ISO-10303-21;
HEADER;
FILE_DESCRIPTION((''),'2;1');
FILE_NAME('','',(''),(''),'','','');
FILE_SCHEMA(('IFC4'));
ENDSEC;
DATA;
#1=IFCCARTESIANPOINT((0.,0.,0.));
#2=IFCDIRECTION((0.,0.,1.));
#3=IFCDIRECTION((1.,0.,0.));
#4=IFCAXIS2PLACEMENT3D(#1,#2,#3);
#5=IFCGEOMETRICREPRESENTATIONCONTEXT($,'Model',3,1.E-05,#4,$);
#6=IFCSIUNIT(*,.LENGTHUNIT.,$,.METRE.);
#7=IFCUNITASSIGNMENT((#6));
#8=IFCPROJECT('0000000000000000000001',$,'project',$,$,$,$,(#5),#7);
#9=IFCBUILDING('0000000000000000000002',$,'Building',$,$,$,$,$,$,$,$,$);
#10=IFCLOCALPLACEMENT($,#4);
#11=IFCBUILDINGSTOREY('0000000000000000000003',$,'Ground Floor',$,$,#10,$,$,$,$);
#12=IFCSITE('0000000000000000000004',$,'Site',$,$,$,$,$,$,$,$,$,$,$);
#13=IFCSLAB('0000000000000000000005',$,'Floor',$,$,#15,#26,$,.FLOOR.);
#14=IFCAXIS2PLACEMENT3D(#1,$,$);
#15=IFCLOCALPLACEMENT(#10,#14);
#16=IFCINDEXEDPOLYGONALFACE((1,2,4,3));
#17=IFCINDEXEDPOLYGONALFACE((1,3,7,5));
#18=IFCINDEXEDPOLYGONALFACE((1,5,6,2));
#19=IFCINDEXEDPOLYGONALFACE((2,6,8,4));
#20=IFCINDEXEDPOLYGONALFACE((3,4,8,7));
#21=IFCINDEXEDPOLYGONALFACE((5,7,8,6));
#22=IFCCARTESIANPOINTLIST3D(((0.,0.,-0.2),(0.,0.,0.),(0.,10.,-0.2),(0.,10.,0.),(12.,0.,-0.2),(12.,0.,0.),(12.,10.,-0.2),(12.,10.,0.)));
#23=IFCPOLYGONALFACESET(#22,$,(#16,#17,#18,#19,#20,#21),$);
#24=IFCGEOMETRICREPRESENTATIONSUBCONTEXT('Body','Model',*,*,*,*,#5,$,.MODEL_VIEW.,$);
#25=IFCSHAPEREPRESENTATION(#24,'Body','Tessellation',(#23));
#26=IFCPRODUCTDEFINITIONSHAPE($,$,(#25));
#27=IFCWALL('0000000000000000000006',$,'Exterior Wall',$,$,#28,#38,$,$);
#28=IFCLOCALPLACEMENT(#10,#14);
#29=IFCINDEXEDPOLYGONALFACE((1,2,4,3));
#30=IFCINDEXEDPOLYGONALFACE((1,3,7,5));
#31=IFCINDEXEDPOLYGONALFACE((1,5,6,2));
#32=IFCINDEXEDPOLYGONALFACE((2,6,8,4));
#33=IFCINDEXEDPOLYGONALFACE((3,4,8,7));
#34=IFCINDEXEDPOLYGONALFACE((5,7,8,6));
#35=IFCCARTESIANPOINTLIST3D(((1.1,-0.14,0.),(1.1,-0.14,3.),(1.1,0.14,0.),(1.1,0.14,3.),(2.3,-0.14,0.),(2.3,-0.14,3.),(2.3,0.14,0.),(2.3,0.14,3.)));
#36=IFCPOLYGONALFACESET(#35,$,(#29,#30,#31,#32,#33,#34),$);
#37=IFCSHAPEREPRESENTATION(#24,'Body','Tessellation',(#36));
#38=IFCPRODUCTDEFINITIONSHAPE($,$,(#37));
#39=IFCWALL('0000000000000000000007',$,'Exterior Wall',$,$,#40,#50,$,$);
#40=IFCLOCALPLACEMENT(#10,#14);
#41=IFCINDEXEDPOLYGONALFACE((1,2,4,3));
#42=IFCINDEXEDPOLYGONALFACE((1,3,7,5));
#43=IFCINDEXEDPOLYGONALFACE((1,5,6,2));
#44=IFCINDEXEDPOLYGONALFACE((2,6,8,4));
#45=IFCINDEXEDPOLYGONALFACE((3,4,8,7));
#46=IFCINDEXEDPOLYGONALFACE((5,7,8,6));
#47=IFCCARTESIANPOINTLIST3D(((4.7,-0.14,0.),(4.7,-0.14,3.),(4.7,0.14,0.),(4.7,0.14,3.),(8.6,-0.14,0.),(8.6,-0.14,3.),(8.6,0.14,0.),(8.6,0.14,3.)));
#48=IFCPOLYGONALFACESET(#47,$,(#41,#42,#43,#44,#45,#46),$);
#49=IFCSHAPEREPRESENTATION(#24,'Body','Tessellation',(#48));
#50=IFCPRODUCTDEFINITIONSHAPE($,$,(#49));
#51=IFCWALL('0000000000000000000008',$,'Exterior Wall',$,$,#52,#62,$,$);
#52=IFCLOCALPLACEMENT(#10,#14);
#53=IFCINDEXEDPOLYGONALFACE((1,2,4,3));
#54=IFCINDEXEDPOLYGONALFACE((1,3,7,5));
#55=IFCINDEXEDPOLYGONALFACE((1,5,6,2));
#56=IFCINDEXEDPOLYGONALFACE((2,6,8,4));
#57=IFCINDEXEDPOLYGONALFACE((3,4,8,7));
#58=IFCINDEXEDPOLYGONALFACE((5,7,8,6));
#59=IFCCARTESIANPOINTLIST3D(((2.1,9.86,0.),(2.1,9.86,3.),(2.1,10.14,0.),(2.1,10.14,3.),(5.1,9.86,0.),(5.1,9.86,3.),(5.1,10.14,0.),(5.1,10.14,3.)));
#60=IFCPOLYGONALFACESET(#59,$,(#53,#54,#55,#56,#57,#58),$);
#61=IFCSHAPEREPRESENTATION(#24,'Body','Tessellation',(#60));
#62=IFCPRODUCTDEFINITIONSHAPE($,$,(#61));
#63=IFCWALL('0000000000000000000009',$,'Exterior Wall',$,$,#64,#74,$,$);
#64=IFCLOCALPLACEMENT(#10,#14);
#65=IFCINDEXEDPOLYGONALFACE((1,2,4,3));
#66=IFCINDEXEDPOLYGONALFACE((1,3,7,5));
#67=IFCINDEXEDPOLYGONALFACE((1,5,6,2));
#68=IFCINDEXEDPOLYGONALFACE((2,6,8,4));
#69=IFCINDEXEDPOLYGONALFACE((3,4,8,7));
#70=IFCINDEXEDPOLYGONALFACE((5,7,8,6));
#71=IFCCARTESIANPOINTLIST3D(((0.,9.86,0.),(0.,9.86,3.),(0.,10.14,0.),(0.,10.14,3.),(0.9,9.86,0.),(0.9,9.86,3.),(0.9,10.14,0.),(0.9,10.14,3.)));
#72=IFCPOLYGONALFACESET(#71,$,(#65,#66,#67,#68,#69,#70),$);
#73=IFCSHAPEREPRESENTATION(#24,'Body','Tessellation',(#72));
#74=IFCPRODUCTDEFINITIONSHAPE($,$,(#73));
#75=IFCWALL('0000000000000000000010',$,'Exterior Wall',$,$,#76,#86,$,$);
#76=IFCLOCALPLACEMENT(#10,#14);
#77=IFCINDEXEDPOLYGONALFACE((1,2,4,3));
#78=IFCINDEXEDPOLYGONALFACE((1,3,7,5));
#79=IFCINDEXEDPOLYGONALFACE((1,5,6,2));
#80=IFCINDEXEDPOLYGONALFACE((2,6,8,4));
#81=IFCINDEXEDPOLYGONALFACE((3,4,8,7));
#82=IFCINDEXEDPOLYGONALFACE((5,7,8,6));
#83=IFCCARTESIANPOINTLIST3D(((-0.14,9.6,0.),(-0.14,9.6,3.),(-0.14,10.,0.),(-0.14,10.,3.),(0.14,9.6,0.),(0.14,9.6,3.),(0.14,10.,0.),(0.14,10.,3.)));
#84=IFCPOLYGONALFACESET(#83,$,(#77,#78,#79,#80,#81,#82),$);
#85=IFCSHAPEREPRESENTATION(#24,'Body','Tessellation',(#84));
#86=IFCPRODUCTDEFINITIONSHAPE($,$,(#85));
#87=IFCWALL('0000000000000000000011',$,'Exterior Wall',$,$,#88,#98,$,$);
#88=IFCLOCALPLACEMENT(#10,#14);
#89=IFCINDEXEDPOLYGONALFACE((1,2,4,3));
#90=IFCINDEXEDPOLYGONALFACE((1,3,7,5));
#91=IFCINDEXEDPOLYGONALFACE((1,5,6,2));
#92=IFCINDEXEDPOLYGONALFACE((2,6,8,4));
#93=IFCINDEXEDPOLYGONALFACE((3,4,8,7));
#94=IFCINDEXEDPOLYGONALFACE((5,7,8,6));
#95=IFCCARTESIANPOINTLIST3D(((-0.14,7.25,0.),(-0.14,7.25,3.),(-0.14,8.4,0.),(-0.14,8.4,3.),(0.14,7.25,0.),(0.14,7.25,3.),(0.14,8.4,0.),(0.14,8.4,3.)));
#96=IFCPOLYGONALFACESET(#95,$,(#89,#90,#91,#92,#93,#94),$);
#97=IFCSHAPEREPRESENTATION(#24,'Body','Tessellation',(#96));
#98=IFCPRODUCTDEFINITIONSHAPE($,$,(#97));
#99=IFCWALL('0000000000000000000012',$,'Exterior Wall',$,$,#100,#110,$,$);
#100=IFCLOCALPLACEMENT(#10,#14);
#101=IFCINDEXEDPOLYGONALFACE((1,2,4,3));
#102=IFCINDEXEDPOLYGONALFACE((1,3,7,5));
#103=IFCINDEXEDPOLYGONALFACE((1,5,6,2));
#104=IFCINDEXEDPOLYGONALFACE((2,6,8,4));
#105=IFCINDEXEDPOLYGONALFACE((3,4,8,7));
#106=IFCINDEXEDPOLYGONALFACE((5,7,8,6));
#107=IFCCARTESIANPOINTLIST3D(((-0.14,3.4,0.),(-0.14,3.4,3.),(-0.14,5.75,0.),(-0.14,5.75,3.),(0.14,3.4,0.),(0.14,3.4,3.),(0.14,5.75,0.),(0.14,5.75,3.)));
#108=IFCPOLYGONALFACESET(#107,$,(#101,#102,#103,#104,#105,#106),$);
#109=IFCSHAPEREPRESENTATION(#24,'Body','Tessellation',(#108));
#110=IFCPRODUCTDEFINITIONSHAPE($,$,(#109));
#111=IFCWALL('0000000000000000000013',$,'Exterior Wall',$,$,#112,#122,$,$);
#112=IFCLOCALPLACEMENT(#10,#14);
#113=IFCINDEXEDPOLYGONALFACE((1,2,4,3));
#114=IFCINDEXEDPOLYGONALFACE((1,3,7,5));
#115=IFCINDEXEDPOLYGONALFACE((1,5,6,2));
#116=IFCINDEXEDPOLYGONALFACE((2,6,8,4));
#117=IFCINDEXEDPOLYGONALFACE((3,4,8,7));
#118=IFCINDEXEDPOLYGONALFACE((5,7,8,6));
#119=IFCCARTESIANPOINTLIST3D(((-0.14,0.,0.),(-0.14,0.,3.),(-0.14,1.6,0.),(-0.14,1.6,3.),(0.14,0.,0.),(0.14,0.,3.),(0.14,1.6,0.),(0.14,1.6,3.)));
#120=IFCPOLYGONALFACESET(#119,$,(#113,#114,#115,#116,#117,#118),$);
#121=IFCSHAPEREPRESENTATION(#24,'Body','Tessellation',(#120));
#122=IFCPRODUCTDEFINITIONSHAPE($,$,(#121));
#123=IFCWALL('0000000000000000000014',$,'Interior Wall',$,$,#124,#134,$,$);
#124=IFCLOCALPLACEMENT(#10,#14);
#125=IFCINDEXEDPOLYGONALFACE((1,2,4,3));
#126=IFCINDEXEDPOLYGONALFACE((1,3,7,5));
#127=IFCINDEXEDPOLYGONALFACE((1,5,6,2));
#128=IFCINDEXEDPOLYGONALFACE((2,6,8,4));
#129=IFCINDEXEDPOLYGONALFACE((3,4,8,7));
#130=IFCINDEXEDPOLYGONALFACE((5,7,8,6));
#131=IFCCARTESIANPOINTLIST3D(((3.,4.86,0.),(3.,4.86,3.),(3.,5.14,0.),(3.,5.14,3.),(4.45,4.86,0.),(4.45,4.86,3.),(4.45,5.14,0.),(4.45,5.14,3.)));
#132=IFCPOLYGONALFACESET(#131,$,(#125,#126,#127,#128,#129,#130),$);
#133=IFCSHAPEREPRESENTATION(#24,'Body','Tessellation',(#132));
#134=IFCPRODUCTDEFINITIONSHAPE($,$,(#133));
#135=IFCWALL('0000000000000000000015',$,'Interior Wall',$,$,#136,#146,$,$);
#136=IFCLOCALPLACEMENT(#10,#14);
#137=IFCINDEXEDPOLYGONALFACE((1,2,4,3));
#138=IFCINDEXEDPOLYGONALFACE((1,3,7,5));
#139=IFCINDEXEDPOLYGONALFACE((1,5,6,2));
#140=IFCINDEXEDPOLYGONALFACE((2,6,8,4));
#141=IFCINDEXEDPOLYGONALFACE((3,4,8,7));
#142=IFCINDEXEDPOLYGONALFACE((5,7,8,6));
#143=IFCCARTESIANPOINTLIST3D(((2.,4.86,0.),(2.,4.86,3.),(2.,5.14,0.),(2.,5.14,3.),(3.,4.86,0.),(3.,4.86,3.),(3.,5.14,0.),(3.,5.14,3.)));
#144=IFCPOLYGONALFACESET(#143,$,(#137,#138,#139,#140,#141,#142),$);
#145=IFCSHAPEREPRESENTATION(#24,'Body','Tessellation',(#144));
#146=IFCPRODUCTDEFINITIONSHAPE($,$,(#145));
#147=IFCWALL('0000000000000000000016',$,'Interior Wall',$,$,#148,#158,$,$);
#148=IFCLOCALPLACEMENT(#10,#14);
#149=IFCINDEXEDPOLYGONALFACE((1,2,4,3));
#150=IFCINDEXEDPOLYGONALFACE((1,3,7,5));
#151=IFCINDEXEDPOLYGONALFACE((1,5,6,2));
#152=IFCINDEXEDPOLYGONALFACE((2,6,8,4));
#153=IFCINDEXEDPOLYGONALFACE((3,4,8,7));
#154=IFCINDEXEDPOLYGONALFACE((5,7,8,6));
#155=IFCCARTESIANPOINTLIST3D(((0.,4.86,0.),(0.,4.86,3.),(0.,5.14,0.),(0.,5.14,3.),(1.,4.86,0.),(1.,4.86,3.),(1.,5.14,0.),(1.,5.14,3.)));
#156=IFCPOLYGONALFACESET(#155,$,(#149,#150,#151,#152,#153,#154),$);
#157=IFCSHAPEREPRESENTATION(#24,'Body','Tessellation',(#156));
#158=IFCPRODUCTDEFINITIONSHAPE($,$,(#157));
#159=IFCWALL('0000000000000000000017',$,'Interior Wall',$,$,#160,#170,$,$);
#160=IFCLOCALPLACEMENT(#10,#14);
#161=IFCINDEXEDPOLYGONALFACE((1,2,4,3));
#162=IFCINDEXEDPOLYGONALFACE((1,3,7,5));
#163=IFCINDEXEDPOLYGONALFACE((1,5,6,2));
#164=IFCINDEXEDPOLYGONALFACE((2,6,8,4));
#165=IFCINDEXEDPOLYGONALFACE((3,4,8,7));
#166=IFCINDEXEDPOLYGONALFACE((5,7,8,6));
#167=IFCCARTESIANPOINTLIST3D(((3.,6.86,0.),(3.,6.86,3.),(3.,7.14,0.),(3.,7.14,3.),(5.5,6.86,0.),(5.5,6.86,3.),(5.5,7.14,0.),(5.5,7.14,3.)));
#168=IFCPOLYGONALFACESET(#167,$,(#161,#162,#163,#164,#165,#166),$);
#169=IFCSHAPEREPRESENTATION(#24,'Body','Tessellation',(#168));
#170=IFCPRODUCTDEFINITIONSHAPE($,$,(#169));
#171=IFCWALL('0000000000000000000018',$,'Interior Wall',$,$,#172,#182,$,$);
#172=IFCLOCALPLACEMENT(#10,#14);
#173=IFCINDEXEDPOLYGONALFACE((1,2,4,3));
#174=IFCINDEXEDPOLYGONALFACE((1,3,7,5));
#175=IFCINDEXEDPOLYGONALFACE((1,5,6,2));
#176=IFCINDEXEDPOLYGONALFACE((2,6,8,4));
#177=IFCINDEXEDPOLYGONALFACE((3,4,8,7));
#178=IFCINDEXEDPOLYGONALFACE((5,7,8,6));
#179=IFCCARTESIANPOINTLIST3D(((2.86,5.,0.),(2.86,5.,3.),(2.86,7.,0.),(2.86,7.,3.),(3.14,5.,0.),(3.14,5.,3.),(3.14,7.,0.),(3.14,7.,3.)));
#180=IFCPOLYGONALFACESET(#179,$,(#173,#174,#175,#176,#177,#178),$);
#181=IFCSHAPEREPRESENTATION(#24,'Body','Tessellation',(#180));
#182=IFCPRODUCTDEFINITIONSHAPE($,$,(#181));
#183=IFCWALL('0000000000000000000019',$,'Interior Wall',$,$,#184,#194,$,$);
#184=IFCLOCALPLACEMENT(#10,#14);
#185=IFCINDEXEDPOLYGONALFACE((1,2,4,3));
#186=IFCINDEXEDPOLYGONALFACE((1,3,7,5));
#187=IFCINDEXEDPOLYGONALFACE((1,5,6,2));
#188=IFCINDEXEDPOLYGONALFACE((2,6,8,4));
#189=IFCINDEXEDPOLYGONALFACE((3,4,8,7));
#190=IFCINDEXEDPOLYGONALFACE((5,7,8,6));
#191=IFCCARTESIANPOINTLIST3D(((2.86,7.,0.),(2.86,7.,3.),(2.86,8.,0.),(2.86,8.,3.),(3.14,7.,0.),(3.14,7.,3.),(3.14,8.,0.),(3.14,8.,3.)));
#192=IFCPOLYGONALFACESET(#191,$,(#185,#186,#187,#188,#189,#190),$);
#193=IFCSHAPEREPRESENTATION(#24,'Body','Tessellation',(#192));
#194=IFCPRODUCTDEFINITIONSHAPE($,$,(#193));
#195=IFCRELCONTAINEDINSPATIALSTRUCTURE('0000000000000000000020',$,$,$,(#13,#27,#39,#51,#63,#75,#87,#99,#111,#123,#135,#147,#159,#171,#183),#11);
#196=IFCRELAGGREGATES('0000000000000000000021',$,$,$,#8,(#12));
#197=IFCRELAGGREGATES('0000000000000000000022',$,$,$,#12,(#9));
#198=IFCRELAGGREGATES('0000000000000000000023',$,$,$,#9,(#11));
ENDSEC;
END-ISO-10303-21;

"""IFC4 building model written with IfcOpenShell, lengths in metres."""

from ifc_helpers import new_model, si_unit, frame, origin_with_axes, place, context, subcontext, project, spatial, indexed_curve, outline, extrude, element, save


model = new_model("IFC4")

# Units and contexts
model_context = context("Model", 3, precision=1e-05, world=origin_with_axes())
body_context = subcontext(model_context, "Body", "Model", "MODEL_VIEW")
ifc_project = project(units=[si_unit("LENGTHUNIT", "METRE")], contexts=[model_context])

# Site, building, storey
site = spatial("IfcSite", under=ifc_project, Name="Site")
building = spatial("IfcBuilding", under=site, Name="Building")
storey_placement = place(None, origin_with_axes())
storey = spatial("IfcBuildingStorey", under=building, at=storey_placement, Name="Ground Floor")

# Slab
slab_placement = place(storey_placement, frame((0.0, 0.0, -0.2), z_axis=(0.0, 0.0, 1.0), x_axis=(1.0, 0.0, 0.0)))
element("IfcSlab", 1, at=slab_placement, inside=storey, Name="Floor", PredefinedType="FLOOR", context=body_context, shape_type="SweptSolid", body=[
    extrude(outline(indexed_curve([(0.0, 0.0), (12.0, 0.0), (12.0, 10.0), (0.0, 10.0)])), None, (0.0, 0.0, 1.0), 0.2),
])

# Walls
wall_1_placement = place(storey_placement, frame((1.1, 0.0, 0.0), z_axis=(0.0, 0.0, 1.0), x_axis=(1.0, 0.0, 0.0)))
element("IfcWall", 2, at=wall_1_placement, inside=storey, Name="Exterior Wall", context=body_context, shape_type="SweptSolid", body=[
    extrude(outline(indexed_curve([(0.0, 0.0), (0.0, 0.28), (1.2, 0.28), (1.2, 0.0), (0.0, 0.0)], self_intersect=False)), frame((0.0, -0.14, 0.0), z_axis=(0.0, 0.0, 1.0), x_axis=(1.0, 0.0, 0.0)), (0.0, 0.0, 1.0), 3.0),
])
wall_2_placement = place(storey_placement, frame((4.7, 0.0, 0.0), z_axis=(0.0, 0.0, 1.0), x_axis=(1.0, 0.0, 0.0)))
element("IfcWall", 3, at=wall_2_placement, inside=storey, Name="Exterior Wall", context=body_context, shape_type="SweptSolid", body=[
    extrude(outline(indexed_curve([(0.0, 0.0), (0.0, 0.28), (3.9, 0.28), (3.9, 0.0), (0.0, 0.0)], self_intersect=False)), frame((0.0, -0.14, 0.0), z_axis=(0.0, 0.0, 1.0), x_axis=(1.0, 0.0, 0.0)), (0.0, 0.0, 1.0), 3.0),
])
wall_3_placement = place(storey_placement, frame((5.1, 10.0, 0.0), z_axis=(0.0, 0.0, 1.0), x_axis=(-1.0, 0.0, 0.0)))
element("IfcWall", 4, at=wall_3_placement, inside=storey, Name="Exterior Wall", context=body_context, shape_type="SweptSolid", body=[
    extrude(outline(indexed_curve([(0.0, 0.0), (0.0, 0.28), (3.0, 0.28), (3.0, 0.0), (0.0, 0.0)], self_intersect=False)), frame((0.0, -0.14, 0.0), z_axis=(0.0, 0.0, 1.0), x_axis=(1.0, 0.0, 0.0)), (0.0, 0.0, 1.0), 3.0),
])
wall_4_placement = place(storey_placement, frame((0.9, 10.0, 0.0), z_axis=(0.0, 0.0, 1.0), x_axis=(-1.0, 0.0, 0.0)))
element("IfcWall", 5, at=wall_4_placement, inside=storey, Name="Exterior Wall", context=body_context, shape_type="SweptSolid", body=[
    extrude(outline(indexed_curve([(0.0, 0.0), (0.0, 0.28), (0.9, 0.28), (0.9, 0.0), (0.0, 0.0)], self_intersect=False)), frame((0.0, -0.14, 0.0), z_axis=(0.0, 0.0, 1.0), x_axis=(1.0, 0.0, 0.0)), (0.0, 0.0, 1.0), 3.0),
])
wall_5_placement = place(storey_placement, frame((0.0, 10.0, 0.0), z_axis=(0.0, 0.0, 1.0), x_axis=(0.0, -1.0, 0.0)))
element("IfcWall", 6, at=wall_5_placement, inside=storey, Name="Exterior Wall", context=body_context, shape_type="SweptSolid", body=[
    extrude(outline(indexed_curve([(0.0, 0.0), (0.0, 0.28), (0.4, 0.28), (0.4, 0.0), (0.0, 0.0)], self_intersect=False)), frame((0.0, -0.14, 0.0), z_axis=(0.0, 0.0, 1.0), x_axis=(1.0, 0.0, 0.0)), (0.0, 0.0, 1.0), 3.0),
])
wall_6_placement = place(storey_placement, frame((0.0, 8.4, 0.0), z_axis=(0.0, 0.0, 1.0), x_axis=(0.0, -1.0, 0.0)))
element("IfcWall", 7, at=wall_6_placement, inside=storey, Name="Exterior Wall", context=body_context, shape_type="SweptSolid", body=[
    extrude(outline(indexed_curve([(0.0, 0.0), (0.0, 0.28), (1.15, 0.28), (1.15, 0.0), (0.0, 0.0)], self_intersect=False)), frame((0.0, -0.14, 0.0), z_axis=(0.0, 0.0, 1.0), x_axis=(1.0, 0.0, 0.0)), (0.0, 0.0, 1.0), 3.0),
])
wall_7_placement = place(storey_placement, frame((0.0, 5.75, 0.0), z_axis=(0.0, 0.0, 1.0), x_axis=(0.0, -1.0, 0.0)))
element("IfcWall", 8, at=wall_7_placement, inside=storey, Name="Exterior Wall", context=body_context, shape_type="SweptSolid", body=[
    extrude(outline(indexed_curve([(0.0, 0.0), (0.0, 0.28), (2.35, 0.28), (2.35, 0.0), (0.0, 0.0)], self_intersect=False)), frame((0.0, -0.14, 0.0), z_axis=(0.0, 0.0, 1.0), x_axis=(1.0, 0.0, 0.0)), (0.0, 0.0, 1.0), 3.0),
])
wall_8_placement = place(storey_placement, frame((0.0, 1.6, 0.0), z_axis=(0.0, 0.0, 1.0), x_axis=(0.0, -1.0, 0.0)))
element("IfcWall", 9, at=wall_8_placement, inside=storey, Name="Exterior Wall", context=body_context, shape_type="SweptSolid", body=[
    extrude(outline(indexed_curve([(0.0, 0.0), (0.0, 0.28), (1.6, 0.28), (1.6, 0.0), (0.0, 0.0)], self_intersect=False)), frame((0.0, -0.14, 0.0), z_axis=(0.0, 0.0, 1.0), x_axis=(1.0, 0.0, 0.0)), (0.0, 0.0, 1.0), 3.0),
])
wall_9_placement = place(storey_placement, frame((4.45, 5.0, 0.0), z_axis=(0.0, 0.0, 1.0), x_axis=(-1.0, 0.0, 0.0)))
element("IfcWall", 10, at=wall_9_placement, inside=storey, Name="Interior Wall", context=body_context, shape_type="SweptSolid", body=[
    extrude(outline(indexed_curve([(0.0, 0.0), (0.0, 0.28), (1.45, 0.28), (1.45, 0.0), (0.0, 0.0)], self_intersect=False)), frame((0.0, -0.14, 0.0), z_axis=(0.0, 0.0, 1.0), x_axis=(1.0, 0.0, 0.0)), (0.0, 0.0, 1.0), 3.0),
])
for number, where, z_axis, x_axis, name in (
    (11, (3.0, 5.0, 0.0), (0.0, 0.0, 1.0), (-1.0, 0.0, 0.0), "Interior Wall"),
    (12, (1.0, 5.0, 0.0), (0.0, 0.0, 1.0), (-1.0, 0.0, 0.0), "Interior Wall"),
):
    element("IfcWall", number, at=place(storey_placement, frame(where, z_axis=z_axis, x_axis=x_axis)), inside=storey, Name=name, context=body_context, shape_type="SweptSolid", body=[
        extrude(outline(indexed_curve([(0.0, 0.0), (0.0, 0.28), (1.0, 0.28), (1.0, 0.0), (0.0, 0.0)], self_intersect=False)), frame((0.0, -0.14, 0.0), z_axis=(0.0, 0.0, 1.0), x_axis=(1.0, 0.0, 0.0)), (0.0, 0.0, 1.0), 3.0),
    ])
wall_10_placement = place(storey_placement, frame((5.5, 7.0, 0.0), z_axis=(0.0, 0.0, 1.0), x_axis=(-1.0, 0.0, 0.0)))
element("IfcWall", 13, at=wall_10_placement, inside=storey, Name="Interior Wall", context=body_context, shape_type="SweptSolid", body=[
    extrude(outline(indexed_curve([(0.0, 0.0), (0.0, 0.28), (2.5, 0.28), (2.5, 0.0), (0.0, 0.0)], self_intersect=False)), frame((0.0, -0.14, 0.0), z_axis=(0.0, 0.0, 1.0), x_axis=(1.0, 0.0, 0.0)), (0.0, 0.0, 1.0), 3.0),
])
wall_11_placement = place(storey_placement, frame((3.0, 7.0, 0.0), z_axis=(0.0, 0.0, 1.0), x_axis=(0.0, -1.0, 0.0)))
element("IfcWall", 14, at=wall_11_placement, inside=storey, Name="Interior Wall", context=body_context, shape_type="SweptSolid", body=[
    extrude(outline(indexed_curve([(0.0, 0.0), (0.0, 0.28), (2.0, 0.28), (2.0, 0.0), (0.0, 0.0)], self_intersect=False)), frame((0.0, -0.14, 0.0), z_axis=(0.0, 0.0, 1.0), x_axis=(1.0, 0.0, 0.0)), (0.0, 0.0, 1.0), 3.0),
])
wall_12_placement = place(storey_placement, frame((3.0, 7.0, 0.0), z_axis=(0.0, 0.0, 1.0), x_axis=(0.0, 1.0, 0.0)))
element("IfcWall", 15, at=wall_12_placement, inside=storey, Name="Interior Wall", context=body_context, shape_type="SweptSolid", body=[
    extrude(outline(indexed_curve([(0.0, 0.0), (0.0, 0.28), (1.0, 0.28), (1.0, 0.0), (0.0, 0.0)], self_intersect=False)), frame((0.0, -0.14, 0.0), z_axis=(0.0, 0.0, 1.0), x_axis=(1.0, 0.0, 0.0)), (0.0, 0.0, 1.0), 3.0),
])

save(model, "model.ifc")
